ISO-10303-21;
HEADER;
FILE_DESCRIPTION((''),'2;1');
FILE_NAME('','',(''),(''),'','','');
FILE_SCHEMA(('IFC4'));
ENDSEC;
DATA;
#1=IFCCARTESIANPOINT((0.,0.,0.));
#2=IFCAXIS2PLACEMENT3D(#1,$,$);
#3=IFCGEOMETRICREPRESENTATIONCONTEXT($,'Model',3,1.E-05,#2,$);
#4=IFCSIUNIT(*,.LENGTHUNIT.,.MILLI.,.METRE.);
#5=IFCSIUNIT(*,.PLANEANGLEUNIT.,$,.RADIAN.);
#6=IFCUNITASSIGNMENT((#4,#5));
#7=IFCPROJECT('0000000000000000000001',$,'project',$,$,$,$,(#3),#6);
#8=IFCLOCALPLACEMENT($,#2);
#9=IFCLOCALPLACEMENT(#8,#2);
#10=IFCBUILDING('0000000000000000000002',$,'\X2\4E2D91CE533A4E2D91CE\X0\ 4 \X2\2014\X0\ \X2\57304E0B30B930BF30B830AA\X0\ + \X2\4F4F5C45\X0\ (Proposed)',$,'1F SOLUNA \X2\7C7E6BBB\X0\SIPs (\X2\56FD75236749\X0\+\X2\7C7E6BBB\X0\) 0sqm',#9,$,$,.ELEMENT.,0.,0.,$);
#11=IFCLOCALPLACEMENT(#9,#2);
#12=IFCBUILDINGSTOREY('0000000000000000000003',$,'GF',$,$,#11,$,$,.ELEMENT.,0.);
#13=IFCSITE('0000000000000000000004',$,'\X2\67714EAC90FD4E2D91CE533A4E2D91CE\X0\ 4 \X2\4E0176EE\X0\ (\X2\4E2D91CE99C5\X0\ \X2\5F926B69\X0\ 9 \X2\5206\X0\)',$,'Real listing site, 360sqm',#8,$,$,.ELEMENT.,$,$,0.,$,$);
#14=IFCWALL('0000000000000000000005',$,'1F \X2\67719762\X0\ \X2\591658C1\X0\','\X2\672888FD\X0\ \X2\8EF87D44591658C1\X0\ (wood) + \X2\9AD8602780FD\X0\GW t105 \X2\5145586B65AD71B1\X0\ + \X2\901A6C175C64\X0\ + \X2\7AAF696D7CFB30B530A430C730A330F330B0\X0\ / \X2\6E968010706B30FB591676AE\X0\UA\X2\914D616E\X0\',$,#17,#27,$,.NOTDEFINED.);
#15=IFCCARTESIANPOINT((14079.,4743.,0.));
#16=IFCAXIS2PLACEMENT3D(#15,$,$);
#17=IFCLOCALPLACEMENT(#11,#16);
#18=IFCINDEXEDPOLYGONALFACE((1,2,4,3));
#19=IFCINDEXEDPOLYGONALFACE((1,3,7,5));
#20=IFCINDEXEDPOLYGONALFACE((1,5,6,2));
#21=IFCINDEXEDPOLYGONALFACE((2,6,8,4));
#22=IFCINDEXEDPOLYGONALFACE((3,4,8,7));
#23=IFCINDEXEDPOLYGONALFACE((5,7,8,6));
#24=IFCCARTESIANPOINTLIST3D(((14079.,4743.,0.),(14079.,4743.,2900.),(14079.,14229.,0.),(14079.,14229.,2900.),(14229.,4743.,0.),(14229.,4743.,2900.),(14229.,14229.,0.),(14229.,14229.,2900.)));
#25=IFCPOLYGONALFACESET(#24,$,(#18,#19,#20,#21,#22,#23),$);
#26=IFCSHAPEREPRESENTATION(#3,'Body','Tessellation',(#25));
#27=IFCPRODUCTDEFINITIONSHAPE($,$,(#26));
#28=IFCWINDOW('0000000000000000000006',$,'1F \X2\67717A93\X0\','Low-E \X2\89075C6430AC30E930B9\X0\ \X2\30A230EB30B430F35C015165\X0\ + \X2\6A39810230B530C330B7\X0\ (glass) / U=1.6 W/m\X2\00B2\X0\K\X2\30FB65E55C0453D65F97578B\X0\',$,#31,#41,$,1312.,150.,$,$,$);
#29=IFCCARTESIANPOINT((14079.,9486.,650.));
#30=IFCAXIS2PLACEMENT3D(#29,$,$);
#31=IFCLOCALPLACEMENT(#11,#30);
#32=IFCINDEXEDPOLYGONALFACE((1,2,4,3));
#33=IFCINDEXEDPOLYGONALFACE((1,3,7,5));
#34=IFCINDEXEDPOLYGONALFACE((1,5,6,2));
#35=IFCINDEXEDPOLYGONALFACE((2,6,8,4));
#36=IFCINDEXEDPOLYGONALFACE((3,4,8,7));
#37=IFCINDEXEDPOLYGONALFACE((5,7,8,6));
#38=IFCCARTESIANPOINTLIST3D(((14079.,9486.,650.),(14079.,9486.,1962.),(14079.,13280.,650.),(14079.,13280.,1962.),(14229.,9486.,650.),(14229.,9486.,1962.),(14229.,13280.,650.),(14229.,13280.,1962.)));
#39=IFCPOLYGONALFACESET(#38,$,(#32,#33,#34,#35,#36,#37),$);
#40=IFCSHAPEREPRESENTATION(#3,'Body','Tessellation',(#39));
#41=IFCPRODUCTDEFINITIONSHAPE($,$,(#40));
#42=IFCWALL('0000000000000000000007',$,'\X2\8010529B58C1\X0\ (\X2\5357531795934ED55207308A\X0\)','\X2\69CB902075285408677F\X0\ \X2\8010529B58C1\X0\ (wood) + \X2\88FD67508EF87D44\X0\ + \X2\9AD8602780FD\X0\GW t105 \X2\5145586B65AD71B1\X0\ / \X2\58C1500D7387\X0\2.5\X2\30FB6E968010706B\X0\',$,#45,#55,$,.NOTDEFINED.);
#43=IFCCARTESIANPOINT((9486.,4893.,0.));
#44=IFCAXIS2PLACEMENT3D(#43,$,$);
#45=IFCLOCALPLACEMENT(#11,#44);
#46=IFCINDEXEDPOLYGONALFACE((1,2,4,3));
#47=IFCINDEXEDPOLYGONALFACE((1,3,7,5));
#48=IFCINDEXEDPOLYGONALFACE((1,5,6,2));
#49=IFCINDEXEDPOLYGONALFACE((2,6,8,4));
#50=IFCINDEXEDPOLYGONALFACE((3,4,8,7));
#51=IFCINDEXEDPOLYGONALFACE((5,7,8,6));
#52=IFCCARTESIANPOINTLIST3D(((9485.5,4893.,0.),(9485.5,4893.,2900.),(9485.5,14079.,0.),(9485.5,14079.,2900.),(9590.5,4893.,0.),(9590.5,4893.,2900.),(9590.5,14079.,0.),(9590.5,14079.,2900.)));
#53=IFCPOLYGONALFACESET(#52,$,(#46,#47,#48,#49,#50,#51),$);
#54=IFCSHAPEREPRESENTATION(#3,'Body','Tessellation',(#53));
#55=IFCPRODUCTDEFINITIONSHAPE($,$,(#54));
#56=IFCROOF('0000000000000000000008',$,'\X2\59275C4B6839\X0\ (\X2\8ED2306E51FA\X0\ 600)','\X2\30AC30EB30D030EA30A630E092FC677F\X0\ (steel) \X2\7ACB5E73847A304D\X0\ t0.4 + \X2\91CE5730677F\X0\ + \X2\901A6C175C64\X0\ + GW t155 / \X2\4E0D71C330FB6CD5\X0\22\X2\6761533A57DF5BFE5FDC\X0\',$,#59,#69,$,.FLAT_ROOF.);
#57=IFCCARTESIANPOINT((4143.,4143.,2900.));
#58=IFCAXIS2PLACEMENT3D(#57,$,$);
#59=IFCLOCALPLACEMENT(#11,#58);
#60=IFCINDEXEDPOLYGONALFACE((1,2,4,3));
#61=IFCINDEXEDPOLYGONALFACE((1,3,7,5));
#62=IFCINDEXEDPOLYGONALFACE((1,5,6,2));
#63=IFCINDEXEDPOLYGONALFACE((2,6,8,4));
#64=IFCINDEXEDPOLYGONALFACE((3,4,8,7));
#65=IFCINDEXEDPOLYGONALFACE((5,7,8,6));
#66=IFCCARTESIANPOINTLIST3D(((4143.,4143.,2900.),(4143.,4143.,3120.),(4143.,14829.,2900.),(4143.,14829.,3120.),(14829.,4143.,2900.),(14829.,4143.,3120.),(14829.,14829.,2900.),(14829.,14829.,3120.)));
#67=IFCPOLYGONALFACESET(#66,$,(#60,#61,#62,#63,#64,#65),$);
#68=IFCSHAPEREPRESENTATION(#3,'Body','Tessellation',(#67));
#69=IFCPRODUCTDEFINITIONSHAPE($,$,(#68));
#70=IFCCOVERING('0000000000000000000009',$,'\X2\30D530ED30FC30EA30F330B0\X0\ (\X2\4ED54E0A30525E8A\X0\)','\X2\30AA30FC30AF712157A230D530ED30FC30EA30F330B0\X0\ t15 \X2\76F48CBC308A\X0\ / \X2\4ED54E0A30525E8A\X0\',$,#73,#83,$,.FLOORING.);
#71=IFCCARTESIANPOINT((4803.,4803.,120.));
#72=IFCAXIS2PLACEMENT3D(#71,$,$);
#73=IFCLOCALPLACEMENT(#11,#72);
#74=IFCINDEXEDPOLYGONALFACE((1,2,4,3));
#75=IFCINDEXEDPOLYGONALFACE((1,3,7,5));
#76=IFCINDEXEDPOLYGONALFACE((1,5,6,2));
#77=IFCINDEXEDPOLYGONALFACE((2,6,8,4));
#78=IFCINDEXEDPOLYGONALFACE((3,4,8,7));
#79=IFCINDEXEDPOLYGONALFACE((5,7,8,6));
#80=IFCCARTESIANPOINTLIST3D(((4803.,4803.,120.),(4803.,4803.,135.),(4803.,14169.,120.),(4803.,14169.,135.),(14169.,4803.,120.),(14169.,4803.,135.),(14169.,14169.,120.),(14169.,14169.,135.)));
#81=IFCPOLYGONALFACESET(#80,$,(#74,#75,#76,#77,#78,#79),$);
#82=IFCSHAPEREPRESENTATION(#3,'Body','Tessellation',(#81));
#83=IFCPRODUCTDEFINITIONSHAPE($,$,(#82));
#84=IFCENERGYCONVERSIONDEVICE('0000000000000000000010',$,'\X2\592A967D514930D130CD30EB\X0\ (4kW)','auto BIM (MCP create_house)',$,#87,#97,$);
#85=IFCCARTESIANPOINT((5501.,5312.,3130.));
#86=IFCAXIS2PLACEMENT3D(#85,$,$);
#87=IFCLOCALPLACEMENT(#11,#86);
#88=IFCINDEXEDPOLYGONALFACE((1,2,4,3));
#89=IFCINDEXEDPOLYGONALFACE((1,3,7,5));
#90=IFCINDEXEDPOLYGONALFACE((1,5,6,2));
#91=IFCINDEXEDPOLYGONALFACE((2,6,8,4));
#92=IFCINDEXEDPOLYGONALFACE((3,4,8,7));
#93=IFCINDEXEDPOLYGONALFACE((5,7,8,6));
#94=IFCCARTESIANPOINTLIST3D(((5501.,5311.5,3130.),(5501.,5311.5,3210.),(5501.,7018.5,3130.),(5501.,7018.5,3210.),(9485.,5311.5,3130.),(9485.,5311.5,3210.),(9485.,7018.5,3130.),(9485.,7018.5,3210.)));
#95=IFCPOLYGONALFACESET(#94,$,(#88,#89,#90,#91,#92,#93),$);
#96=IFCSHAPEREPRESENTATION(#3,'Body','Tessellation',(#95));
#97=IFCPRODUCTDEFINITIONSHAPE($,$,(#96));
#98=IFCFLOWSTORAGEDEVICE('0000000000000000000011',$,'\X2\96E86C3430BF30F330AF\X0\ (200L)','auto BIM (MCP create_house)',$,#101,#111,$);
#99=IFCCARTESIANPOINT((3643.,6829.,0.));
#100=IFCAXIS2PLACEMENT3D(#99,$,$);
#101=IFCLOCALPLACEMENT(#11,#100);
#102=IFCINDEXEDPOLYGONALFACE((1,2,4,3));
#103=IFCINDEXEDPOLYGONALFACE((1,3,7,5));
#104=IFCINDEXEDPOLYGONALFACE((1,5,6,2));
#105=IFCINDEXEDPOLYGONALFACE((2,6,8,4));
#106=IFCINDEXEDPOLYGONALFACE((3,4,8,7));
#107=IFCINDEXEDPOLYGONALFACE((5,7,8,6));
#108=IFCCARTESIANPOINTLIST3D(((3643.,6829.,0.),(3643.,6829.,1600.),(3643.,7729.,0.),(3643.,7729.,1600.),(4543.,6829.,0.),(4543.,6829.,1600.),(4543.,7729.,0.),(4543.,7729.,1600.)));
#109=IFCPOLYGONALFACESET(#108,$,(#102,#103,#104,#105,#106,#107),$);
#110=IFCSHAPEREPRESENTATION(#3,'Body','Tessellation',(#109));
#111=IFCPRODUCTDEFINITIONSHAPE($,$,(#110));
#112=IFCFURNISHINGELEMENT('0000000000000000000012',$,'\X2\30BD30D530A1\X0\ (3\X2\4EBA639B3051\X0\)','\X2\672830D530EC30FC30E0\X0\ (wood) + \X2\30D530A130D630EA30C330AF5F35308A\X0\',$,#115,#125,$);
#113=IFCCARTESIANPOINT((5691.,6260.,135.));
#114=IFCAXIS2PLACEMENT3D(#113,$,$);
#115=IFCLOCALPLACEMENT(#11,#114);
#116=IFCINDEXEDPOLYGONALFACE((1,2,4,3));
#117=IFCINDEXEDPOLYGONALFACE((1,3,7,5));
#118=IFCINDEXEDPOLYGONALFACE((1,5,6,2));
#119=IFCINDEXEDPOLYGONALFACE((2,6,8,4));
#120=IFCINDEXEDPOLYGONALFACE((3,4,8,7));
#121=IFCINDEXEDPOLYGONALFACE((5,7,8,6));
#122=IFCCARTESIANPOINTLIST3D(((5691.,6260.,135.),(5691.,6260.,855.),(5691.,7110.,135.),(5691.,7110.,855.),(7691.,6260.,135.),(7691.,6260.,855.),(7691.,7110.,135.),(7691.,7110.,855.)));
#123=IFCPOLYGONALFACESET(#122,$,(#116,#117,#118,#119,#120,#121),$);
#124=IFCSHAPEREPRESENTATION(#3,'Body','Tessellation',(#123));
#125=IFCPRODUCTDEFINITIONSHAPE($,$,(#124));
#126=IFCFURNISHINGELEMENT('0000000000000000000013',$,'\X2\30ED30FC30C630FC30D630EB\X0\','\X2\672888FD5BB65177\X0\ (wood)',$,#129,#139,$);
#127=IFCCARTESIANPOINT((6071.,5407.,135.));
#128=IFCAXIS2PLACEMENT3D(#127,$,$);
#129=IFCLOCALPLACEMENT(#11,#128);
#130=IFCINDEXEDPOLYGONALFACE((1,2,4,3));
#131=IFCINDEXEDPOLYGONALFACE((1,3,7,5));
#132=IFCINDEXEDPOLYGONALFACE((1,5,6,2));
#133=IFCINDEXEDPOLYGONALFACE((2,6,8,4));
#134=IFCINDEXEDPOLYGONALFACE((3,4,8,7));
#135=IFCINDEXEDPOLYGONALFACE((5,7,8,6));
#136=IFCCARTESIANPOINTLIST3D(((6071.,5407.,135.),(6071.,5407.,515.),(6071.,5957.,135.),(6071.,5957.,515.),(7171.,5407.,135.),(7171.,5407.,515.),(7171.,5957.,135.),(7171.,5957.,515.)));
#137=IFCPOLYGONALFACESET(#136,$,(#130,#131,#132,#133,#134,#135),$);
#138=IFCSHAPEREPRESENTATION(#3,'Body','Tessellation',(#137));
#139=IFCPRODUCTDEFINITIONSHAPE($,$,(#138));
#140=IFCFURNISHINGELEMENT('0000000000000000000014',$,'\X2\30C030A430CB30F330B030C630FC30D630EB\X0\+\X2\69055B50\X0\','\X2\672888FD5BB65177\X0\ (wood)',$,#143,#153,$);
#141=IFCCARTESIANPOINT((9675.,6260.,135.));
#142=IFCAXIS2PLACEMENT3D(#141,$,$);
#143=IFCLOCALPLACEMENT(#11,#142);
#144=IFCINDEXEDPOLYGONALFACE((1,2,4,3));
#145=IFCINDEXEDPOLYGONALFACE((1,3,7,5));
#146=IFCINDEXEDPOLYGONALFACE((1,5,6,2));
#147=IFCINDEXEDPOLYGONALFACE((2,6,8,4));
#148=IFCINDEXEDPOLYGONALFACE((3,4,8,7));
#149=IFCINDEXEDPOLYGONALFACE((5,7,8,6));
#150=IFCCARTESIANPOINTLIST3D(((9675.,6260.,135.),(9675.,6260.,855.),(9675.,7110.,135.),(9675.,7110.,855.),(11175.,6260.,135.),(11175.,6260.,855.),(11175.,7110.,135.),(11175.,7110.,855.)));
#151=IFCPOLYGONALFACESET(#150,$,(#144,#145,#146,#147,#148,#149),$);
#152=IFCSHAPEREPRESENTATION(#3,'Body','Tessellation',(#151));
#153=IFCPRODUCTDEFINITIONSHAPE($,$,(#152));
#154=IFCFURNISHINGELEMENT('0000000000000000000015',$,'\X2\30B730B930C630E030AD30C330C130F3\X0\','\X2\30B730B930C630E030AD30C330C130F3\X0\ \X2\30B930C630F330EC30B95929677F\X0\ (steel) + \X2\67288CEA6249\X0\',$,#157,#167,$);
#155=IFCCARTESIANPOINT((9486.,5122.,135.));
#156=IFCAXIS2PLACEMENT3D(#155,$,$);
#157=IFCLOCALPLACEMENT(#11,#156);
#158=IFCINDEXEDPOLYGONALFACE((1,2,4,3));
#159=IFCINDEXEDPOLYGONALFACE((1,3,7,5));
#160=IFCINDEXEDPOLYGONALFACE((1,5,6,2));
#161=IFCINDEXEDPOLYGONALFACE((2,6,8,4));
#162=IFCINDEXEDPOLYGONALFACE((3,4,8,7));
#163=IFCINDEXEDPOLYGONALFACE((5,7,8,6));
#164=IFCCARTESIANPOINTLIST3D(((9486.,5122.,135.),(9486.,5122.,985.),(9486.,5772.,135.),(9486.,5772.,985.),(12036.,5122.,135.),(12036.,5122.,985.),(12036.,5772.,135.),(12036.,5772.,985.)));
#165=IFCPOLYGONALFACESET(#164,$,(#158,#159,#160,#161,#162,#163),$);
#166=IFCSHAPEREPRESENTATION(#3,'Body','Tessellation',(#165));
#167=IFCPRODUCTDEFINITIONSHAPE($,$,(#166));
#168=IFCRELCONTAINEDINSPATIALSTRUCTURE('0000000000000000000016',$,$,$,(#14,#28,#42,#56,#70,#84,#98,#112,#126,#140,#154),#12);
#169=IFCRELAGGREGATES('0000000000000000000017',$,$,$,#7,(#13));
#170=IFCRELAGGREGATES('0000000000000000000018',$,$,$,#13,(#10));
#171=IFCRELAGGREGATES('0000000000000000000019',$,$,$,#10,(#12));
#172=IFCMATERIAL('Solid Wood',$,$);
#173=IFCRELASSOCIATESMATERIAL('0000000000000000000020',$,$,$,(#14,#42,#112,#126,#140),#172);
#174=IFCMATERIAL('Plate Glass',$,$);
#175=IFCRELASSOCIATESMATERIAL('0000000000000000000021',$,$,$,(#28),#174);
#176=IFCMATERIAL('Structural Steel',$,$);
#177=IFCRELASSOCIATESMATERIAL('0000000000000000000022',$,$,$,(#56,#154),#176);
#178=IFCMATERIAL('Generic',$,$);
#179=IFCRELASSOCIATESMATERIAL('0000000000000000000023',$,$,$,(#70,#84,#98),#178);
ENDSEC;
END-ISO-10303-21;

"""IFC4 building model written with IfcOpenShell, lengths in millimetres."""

from ifc_helpers import new_model, si_unit, frame, frame_2d, origin, place, context, project, spatial, rectangle, extrude, material, element, fill, save


model = new_model("IFC4")

# Units and contexts
model_context = context("Model", 3, precision=1e-05, world=origin())
ifc_project = project(units=[si_unit("LENGTHUNIT", "METRE", prefix="MILLI"), si_unit("PLANEANGLEUNIT", "RADIAN")], contexts=[model_context])

# Site, building, storey
site_placement = place(None, origin())
site = spatial("IfcSite", under=ifc_project, at=site_placement, Name="東京都中野区中野 4 丁目 (中野駅 徒歩 9 分)", ObjectType="Real listing site, 360sqm", CompositionType="ELEMENT", RefElevation=0.0)
building_placement = place(site_placement, origin())
building = spatial("IfcBuilding", under=site, at=building_placement, Name="中野区中野 4 — 地下スタジオ + 住居 (Proposed)", ObjectType="1F SOLUNA 籾殻SIPs (国産杉+籾殻) 0sqm", CompositionType="ELEMENT", ElevationOfRefHeight=0.0, ElevationOfTerrain=0.0)
storey_placement = place(building_placement, origin())
storey = spatial("IfcBuildingStorey", under=building, at=storey_placement, Name="GF", CompositionType="ELEMENT", Elevation=0.0)

# Shared definitions
ifc_material_1 = material(Name="Solid Wood")

# Shared definitions
ifc_material_2 = material(Name="Plate Glass")

# Wall, opening, window
wall_1_placement = place(storey_placement, frame((14079.0, 4743.0, 0.0)))
wall_1 = element("IfcWall", 1, at=wall_1_placement, inside=storey, material=ifc_material_1, Name="1F 東面 外壁", Description="木製 軸組外壁 (wood) + 高性能GW t105 充填断熱 + 通気層 + 窯業系サイディング / 準耐火・外皮UA配慮", PredefinedType="NOTDEFINED", context=model_context, shape_type="SweptSolid", body=[
    extrude(rectangle(XDim=150.0, YDim=9486.0, at=frame_2d((75.0, 4743.0))), frame((14079.0, 4743.0, 0.0)), (0.0, 0.0, 1.0), 2900.0),
])
opening_1_placement = place(storey_placement, frame((14079.0, 9486.0, 650.0)))
opening_1 = element("IfcOpeningElement", 2, at=opening_1_placement, cuts=wall_1, PredefinedType="NOTDEFINED", context=model_context, shape_type="SweptSolid", body=[
    extrude(rectangle(XDim=150.0, YDim=3794.0, at=frame_2d((75.0, 1897.0))), frame((14079.0, 9486.0, 650.0)), (0.0, 0.0, 1.0), 1312.0),
])
window_1_placement = place(storey_placement, frame((14079.0, 9486.0, 650.0)))
window_1 = element("IfcWindow", 3, at=window_1_placement, inside=storey, material=ifc_material_2, Name="1F 東窓", Description="Low-E 複層ガラス アルゴン封入 + 樹脂サッシ (glass) / U=1.6 W/m²K・日射取得型", OverallHeight=1312.0, OverallWidth=150.0, context=model_context, shape_type="SweptSolid", body=[
    extrude(rectangle(XDim=150.0, YDim=3794.0, at=frame_2d((75.0, 1897.0))), frame((14079.0, 9486.0, 650.0)), (0.0, 0.0, 1.0), 1312.0),
])
fill(opening_1, window_1)

# Wall
wall_2_placement = place(storey_placement, frame((9486.0, 4893.0, 0.0)))
element("IfcWall", 4, at=wall_2_placement, inside=storey, material=ifc_material_1, Name="耐力壁 (南北間仕切り)", Description="構造用合板 耐力壁 (wood) + 製材軸組 + 高性能GW t105 充填断熱 / 壁倍率2.5・準耐火", PredefinedType="NOTDEFINED", context=model_context, shape_type="SweptSolid", body=[
    extrude(rectangle(XDim=105.0, YDim=9186.0, at=frame_2d((52.0, 4593.0))), frame((9486.0, 4893.0, 0.0)), (0.0, 0.0, 1.0), 2900.0),
])

# Roof
ifc_material_3 = material(Name="Structural Steel")
roof_placement = place(storey_placement, frame((4143.0, 4143.0, 2900.0)))
element("IfcRoof", 5, at=roof_placement, inside=storey, material=ifc_material_3, Name="大屋根 (軒の出 600)", Description="ガルバリウム鋼板 (steel) 立平葺き t0.4 + 野地板 + 通気層 + GW t155 / 不燃・法22条区域対応", PredefinedType="FLAT_ROOF", context=model_context, shape_type="SweptSolid", body=[
    extrude(rectangle(XDim=10686.0, YDim=10686.0, at=frame_2d((5343.0, 5343.0))), frame((4143.0, 4143.0, 2900.0)), (0.0, 0.0, 1.0), 220.0),
])

# Covering
ifc_material_4 = material(Name="Generic")
covering_placement = place(storey_placement, frame((4803.0, 4803.0, 120.0)))
element("IfcCovering", 6, at=covering_placement, inside=storey, material=ifc_material_4, Name="フローリング (仕上げ床)", Description="オーク無垢フローリング t15 直貼り / 仕上げ床", PredefinedType="FLOORING", context=model_context, shape_type="SweptSolid", body=[
    extrude(rectangle(XDim=9366.0, YDim=9366.0, at=frame_2d((4683.0, 4683.0))), frame((4803.0, 4803.0, 120.0)), (0.0, 0.0, 1.0), 15.0),
])

# Energy conversion device
energy_conversion_device_placement = place(storey_placement, frame((5501.0, 5312.0, 3130.0)))
element("IfcEnergyConversionDevice", 7, at=energy_conversion_device_placement, inside=storey, material=ifc_material_4, Name="太陽光パネル (4kW)", Description="auto BIM (MCP create_house)", context=model_context, shape_type="SweptSolid", body=[
    extrude(rectangle(XDim=3984.0, YDim=1707.0, at=frame_2d((1992.0, 853.0))), frame((5501.0, 5312.0, 3130.0)), (0.0, 0.0, 1.0), 80.0),
])

# Flow storage device
flow_storage_device_placement = place(storey_placement, frame((3643.0, 6829.0, 0.0)))
element("IfcFlowStorageDevice", 8, at=flow_storage_device_placement, inside=storey, material=ifc_material_4, Name="雨水タンク (200L)", Description="auto BIM (MCP create_house)", context=model_context, shape_type="SweptSolid", body=[
    extrude(rectangle(XDim=900.0, YDim=900.0, at=frame_2d((450.0, 450.0))), frame((3643.0, 6829.0, 0.0)), (0.0, 0.0, 1.0), 1600.0),
])

# Furnishing elements
furnishing_1_placement = place(storey_placement, frame((5691.0, 6260.0, 135.0)))
element("IfcFurnishingElement", 9, at=furnishing_1_placement, inside=storey, material=ifc_material_1, Name="ソファ (3人掛け)", Description="木フレーム (wood) + ファブリック張り", context=model_context, shape_type="SweptSolid", body=[
    extrude(rectangle(XDim=2000.0, YDim=850.0, at=frame_2d((1000.0, 425.0))), frame((5691.0, 6260.0, 135.0)), (0.0, 0.0, 1.0), 720.0),
])
furnishing_2_placement = place(storey_placement, frame((6071.0, 5407.0, 135.0)))
element("IfcFurnishingElement", 10, at=furnishing_2_placement, inside=storey, material=ifc_material_1, Name="ローテーブル", Description="木製家具 (wood)", context=model_context, shape_type="SweptSolid", body=[
    extrude(rectangle(XDim=1100.0, YDim=550.0, at=frame_2d((550.0, 275.0))), frame((6071.0, 5407.0, 135.0)), (0.0, 0.0, 1.0), 380.0),
])
furnishing_3_placement = place(storey_placement, frame((9675.0, 6260.0, 135.0)))
element("IfcFurnishingElement", 11, at=furnishing_3_placement, inside=storey, material=ifc_material_1, Name="ダイニングテーブル+椅子", Description="木製家具 (wood)", context=model_context, shape_type="SweptSolid", body=[
    extrude(rectangle(XDim=1500.0, YDim=850.0, at=frame_2d((750.0, 425.0))), frame((9675.0, 6260.0, 135.0)), (0.0, 0.0, 1.0), 720.0),
])
furnishing_4_placement = place(storey_placement, frame((9486.0, 5122.0, 135.0)))
element("IfcFurnishingElement", 12, at=furnishing_4_placement, inside=storey, material=ifc_material_3, Name="システムキッチン", Description="システムキッチン ステンレス天板 (steel) + 木質扉", context=model_context, shape_type="SweptSolid", body=[
    extrude(rectangle(XDim=2550.0, YDim=650.0, at=frame_2d((1275.0, 325.0))), frame((9486.0, 5122.0, 135.0)), (0.0, 0.0, 1.0), 850.0),
])

save(model, "model.ifc")
